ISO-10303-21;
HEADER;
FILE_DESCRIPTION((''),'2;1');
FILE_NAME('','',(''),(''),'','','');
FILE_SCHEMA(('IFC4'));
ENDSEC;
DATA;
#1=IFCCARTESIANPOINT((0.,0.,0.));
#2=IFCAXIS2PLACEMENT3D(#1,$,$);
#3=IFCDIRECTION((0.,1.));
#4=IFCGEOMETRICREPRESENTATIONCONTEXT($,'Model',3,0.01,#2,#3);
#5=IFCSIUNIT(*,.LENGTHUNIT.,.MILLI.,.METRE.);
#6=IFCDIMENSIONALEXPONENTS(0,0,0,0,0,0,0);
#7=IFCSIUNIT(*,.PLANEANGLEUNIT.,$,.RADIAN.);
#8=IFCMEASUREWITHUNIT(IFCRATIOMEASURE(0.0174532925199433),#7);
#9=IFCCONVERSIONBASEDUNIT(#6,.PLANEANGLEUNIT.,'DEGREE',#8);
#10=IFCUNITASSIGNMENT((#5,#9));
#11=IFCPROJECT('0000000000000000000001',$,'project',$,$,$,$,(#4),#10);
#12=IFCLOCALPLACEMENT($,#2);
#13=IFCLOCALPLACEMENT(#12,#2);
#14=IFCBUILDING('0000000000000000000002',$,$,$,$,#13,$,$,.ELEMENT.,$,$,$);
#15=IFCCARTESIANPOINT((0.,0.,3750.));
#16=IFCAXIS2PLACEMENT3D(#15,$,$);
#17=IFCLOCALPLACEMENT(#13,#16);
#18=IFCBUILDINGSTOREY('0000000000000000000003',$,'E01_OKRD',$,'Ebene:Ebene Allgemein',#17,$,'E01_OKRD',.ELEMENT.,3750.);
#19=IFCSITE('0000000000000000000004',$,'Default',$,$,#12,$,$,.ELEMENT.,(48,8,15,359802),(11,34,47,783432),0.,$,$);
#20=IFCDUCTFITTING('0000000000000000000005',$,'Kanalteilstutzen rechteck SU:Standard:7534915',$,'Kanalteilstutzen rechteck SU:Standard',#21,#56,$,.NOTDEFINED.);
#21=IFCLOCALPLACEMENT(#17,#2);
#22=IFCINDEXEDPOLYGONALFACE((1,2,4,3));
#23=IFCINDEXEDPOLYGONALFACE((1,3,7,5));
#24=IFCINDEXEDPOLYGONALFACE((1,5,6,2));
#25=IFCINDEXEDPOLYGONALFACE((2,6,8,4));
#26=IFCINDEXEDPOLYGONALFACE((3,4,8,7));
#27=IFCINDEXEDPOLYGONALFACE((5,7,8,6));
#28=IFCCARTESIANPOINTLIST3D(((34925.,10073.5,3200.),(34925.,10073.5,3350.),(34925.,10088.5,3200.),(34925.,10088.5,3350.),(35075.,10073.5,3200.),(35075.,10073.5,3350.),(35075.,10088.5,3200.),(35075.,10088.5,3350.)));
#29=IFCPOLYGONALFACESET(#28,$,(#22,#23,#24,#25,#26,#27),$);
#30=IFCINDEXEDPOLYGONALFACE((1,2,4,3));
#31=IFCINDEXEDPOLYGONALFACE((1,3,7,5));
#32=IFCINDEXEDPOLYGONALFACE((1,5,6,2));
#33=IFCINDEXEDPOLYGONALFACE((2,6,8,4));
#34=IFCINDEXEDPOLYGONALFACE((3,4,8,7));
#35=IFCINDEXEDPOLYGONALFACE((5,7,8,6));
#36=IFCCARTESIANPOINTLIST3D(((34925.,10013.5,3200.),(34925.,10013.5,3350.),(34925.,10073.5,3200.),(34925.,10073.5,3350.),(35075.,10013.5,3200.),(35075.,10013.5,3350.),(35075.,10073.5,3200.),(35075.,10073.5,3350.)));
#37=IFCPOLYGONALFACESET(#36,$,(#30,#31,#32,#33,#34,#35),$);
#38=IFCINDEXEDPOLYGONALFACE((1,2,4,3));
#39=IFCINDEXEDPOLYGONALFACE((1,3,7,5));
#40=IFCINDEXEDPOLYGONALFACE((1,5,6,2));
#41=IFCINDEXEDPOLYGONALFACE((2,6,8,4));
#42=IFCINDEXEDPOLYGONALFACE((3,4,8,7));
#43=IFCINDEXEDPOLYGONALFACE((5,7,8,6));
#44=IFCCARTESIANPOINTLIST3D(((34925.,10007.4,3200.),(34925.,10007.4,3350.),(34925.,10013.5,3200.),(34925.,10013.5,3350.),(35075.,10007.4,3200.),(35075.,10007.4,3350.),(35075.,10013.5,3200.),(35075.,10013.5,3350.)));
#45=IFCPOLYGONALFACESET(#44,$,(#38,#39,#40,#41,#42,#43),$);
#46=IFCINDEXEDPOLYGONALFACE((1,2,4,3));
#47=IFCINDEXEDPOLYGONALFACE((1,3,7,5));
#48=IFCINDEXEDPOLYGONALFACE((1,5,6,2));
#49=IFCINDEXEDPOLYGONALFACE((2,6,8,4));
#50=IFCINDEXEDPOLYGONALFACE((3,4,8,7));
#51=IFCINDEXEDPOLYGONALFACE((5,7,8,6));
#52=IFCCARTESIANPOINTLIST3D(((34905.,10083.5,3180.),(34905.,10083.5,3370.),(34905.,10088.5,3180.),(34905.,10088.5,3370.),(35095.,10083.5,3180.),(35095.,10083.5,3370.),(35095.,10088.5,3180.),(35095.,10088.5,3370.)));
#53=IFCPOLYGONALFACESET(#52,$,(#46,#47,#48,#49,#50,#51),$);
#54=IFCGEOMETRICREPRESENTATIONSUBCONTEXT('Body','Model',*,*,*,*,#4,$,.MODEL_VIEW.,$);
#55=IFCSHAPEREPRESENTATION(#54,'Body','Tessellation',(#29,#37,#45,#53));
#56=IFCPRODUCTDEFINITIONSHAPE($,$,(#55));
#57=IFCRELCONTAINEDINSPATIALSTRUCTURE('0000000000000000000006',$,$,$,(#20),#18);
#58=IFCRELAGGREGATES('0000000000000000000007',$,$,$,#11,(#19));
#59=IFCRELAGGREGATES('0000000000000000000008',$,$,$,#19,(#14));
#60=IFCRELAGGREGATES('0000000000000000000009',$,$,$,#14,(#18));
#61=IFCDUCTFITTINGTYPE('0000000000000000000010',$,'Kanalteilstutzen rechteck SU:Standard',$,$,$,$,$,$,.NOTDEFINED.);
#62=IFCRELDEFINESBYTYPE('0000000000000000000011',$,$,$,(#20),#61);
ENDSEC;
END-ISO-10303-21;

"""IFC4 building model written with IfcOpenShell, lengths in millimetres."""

from ifc_helpers import new_model, entity, si_unit, converted_unit, direction, frame, frame_2d, origin, origin_2d_with_axis, place, context, subcontext, project, spatial, rectangle, extrude, source, transform, mapped, type_object, type_shapes, element, save


model = new_model("IFC4")

# Units and contexts
model_context = context("Model", 3, precision=0.01, world=origin(), true_north=direction((0.0, 1.0)))
body_context = subcontext(model_context, "Body", "Model", "MODEL_VIEW")
ifc_project = project(units=[si_unit("LENGTHUNIT", "METRE", prefix="MILLI"), converted_unit("PLANEANGLEUNIT", "DEGREE", entity("IfcRatioMeasure", 0.0174532925199433), si_unit("PLANEANGLEUNIT", "RADIAN"), dimensions=[0, 0, 0, 0, 0, 0, 0])], contexts=[model_context])

# Site, building, storey
site_placement = place(None, origin())
site = spatial("IfcSite", under=ifc_project, at=site_placement, Name="Default", CompositionType="ELEMENT", RefLatitude=(48, 8, 15, 359802), RefLongitude=(11, 34, 47, 783432), RefElevation=0.0)
building_placement = place(site_placement, origin())
building = spatial("IfcBuilding", under=site, at=building_placement, CompositionType="ELEMENT")
storey_placement = place(building_placement, frame((0.0, 0.0, 3750.0)))
storey = spatial("IfcBuildingStorey", under=building, at=storey_placement, Name="E01_OKRD", ObjectType="Ebene:Ebene Allgemein", LongName="E01_OKRD", CompositionType="ELEMENT", Elevation=3750.0)

# Duct fitting
duct_fitting_type_1 = type_object("IfcDuctFittingType", Name="Kanalteilstutzen rechteck SU:Standard", PredefinedType="NOTDEFINED")
shared_shape_1 = source(origin(), body_context, "Body", "SweptSolid", [
    extrude(rectangle(XDim=15.0, YDim=150.0, at=origin_2d_with_axis()), frame((67.5, 0.0, -75.0)), (0.0, 0.0, 1.0), 150.0),
    extrude(rectangle(XDim=60.0, YDim=150.0, at=frame_2d((0.0, 0.0), x_axis=(1.0, 0.0))), frame((30.0, 0.0, -75.0)), (0.0, 0.0, 1.0), 150.0),
    extrude(rectangle(XDim=6.1, YDim=150.0, at=frame_2d((0.0, 0.0), x_axis=(1.0, 0.0))), frame((-3.0, 0.0, -75.0)), (0.0, 0.0, 1.0), 150.0),
    extrude(rectangle(XDim=5.0, YDim=190.0, at=origin_2d_with_axis()), frame((72.5, 0.0, -95.0)), (0.0, 0.0, 1.0), 190.0),
])
type_shapes(duct_fitting_type_1, [shared_shape_1])
duct_fitting_1_placement = place(storey_placement, frame((35000.0, 10013.5, 3275.0), z_axis=(0.0, 0.000046, -1.0), x_axis=(0.0, 1.0, 0.000046)))
element("IfcDuctFitting", 1, at=duct_fitting_1_placement, inside=storey, type_object=duct_fitting_type_1, Name="Kanalteilstutzen rechteck SU:Standard:7534915", ObjectType="Kanalteilstutzen rechteck SU:Standard", PredefinedType="NOTDEFINED", context=body_context, shape_type="MappedRepresentation", body=[
    mapped(shared_shape_1, transform((0.0, 0.0, 0.0), scale=1.0)),
])

save(model, "model.ifc")
